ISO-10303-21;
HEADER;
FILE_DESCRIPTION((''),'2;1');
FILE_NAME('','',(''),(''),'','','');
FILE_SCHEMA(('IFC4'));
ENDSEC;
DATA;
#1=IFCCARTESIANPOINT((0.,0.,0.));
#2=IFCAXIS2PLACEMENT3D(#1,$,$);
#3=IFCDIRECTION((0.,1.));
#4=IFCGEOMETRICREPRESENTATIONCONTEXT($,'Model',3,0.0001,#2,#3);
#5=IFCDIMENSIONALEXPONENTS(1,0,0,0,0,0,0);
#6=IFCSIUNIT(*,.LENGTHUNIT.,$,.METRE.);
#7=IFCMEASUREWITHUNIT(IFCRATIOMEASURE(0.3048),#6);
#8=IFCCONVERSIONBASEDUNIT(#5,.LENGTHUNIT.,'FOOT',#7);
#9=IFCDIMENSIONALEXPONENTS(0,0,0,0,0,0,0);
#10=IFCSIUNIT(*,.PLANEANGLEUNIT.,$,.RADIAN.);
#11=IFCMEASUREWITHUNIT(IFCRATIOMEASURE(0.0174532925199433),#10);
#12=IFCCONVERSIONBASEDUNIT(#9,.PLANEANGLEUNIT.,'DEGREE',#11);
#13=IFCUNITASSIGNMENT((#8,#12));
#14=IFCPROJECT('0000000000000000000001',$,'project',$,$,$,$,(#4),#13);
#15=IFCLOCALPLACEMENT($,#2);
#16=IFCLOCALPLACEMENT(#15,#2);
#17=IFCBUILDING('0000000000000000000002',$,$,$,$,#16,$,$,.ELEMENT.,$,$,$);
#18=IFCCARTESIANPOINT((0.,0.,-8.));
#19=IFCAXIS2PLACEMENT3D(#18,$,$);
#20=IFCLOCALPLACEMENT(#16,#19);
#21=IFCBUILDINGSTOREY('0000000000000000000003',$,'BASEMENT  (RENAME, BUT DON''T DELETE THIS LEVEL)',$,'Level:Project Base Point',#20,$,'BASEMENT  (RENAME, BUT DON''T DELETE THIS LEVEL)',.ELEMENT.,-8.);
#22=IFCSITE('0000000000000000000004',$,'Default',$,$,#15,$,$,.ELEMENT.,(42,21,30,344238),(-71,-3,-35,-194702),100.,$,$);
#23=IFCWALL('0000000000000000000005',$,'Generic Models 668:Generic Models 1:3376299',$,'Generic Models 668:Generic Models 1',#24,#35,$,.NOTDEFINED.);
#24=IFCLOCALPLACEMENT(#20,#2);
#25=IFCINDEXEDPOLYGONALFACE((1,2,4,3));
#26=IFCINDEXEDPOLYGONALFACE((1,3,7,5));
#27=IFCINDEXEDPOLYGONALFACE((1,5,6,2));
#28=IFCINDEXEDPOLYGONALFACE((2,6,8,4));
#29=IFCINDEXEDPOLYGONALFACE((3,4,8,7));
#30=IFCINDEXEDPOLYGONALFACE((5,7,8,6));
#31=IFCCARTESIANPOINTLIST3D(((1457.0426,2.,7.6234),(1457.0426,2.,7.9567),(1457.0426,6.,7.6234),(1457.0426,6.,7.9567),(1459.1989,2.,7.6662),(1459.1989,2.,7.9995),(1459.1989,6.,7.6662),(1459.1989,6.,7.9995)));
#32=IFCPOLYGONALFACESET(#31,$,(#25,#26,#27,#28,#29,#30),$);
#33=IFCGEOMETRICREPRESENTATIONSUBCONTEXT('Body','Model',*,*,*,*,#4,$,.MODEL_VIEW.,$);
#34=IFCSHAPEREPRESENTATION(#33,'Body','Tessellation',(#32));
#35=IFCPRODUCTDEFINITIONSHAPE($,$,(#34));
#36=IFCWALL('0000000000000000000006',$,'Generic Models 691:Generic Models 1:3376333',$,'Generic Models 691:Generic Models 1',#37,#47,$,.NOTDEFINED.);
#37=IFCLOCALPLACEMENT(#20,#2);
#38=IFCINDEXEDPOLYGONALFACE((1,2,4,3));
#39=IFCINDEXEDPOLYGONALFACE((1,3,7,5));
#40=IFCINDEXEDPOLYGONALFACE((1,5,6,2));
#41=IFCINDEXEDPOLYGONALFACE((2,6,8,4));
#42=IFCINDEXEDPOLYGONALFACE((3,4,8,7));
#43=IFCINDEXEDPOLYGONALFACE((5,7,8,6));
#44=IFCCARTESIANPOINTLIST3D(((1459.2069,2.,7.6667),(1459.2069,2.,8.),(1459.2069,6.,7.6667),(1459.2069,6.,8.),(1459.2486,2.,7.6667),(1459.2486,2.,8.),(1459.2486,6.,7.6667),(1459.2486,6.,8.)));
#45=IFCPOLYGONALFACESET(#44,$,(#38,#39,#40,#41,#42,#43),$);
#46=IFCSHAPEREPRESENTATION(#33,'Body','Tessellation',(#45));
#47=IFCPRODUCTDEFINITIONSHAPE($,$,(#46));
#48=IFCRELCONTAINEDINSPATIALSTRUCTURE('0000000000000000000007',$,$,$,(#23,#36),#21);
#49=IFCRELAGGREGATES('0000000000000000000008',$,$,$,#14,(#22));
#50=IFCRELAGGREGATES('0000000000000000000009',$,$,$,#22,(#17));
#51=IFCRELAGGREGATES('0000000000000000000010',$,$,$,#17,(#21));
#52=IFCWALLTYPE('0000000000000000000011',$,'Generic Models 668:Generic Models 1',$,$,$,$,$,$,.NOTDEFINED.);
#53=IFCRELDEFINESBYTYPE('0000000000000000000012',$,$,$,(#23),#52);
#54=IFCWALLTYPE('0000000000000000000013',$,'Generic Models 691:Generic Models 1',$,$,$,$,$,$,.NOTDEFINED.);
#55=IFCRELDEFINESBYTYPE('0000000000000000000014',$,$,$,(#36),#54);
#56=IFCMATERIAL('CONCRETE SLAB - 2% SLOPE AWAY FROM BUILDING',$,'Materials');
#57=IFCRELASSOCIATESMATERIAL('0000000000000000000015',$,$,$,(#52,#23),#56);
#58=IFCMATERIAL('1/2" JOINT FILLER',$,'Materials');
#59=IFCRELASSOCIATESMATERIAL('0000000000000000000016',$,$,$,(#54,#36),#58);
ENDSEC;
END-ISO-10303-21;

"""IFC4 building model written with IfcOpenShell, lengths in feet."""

from ifc_helpers import new_model, entity, si_unit, converted_unit, direction, frame, frame_2d, origin, place, context, subcontext, project, spatial, rectangle, extrude, material, type_object, element, save


model = new_model("IFC4")

# Units and contexts
model_context = context("Model", 3, precision=0.0001, world=origin(), true_north=direction((0.0, 1.0)))
body_context = subcontext(model_context, "Body", "Model", "MODEL_VIEW")
ifc_project = project(units=[converted_unit("LENGTHUNIT", "FOOT", entity("IfcRatioMeasure", 0.3048), si_unit("LENGTHUNIT", "METRE"), dimensions=[1, 0, 0, 0, 0, 0, 0]), converted_unit("PLANEANGLEUNIT", "DEGREE", entity("IfcRatioMeasure", 0.0174532925199433), si_unit("PLANEANGLEUNIT", "RADIAN"), dimensions=[0, 0, 0, 0, 0, 0, 0])], contexts=[model_context])

# Site, building, storey
site_placement = place(None, origin())
site = spatial("IfcSite", under=ifc_project, at=site_placement, Name="Default", CompositionType="ELEMENT", RefLatitude=(42, 21, 30, 344238), RefLongitude=(-71, -3, -35, -194702), RefElevation=100.0)
building_placement = place(site_placement, origin())
building = spatial("IfcBuilding", under=site, at=building_placement, CompositionType="ELEMENT")
storey_placement = place(building_placement, frame((0.0, 0.0, -8.0)))
storey = spatial("IfcBuildingStorey", under=building, at=storey_placement, Name="BASEMENT  (RENAME, BUT DON'T DELETE THIS LEVEL)", ObjectType="Level:Project Base Point", LongName="BASEMENT  (RENAME, BUT DON'T DELETE THIS LEVEL)", CompositionType="ELEMENT", Elevation=-8.0)

# Walls
ifc_material_1 = material(Name="CONCRETE SLAB - 2% SLOPE AWAY FROM BUILDING", Category="Materials")
wall_type_1 = type_object("IfcWallType", Name="Generic Models 668:Generic Models 1", PredefinedType="NOTDEFINED", material=ifc_material_1)
wall_1_placement = place(storey_placement, frame((1457.0426, 2.0, 7.6234), z_axis=(0.0, 0.0, 1.0), x_axis=(0.0, 1.0, 0.0)))
element("IfcWall", 1, at=wall_1_placement, inside=storey, type_object=wall_type_1, material=ifc_material_1, Name="Generic Models 668:Generic Models 1:3376299", ObjectType="Generic Models 668:Generic Models 1", PredefinedType="NOTDEFINED", context=body_context, shape_type="SweptSolid", body=[
    extrude(rectangle(XDim=2.1567, YDim=4.0, at=frame_2d((0.0, 0.0), x_axis=(0.0, 1.0))), frame((2.0, -1.0781, 0.0214), z_axis=(0.0, 0.019853, 0.999803), x_axis=(1.0, 0.0, 0.0)), (0.0, -0.019853, 0.999803), 0.3333),
])
ifc_material_2 = material(Name="1/2\" JOINT FILLER", Category="Materials")
wall_type_2 = type_object("IfcWallType", Name="Generic Models 691:Generic Models 1", PredefinedType="NOTDEFINED", material=ifc_material_2)
wall_2_placement = place(storey_placement, frame((1459.2069, 2.0, 7.6667), z_axis=(0.0, 0.0, 1.0), x_axis=(0.0, 1.0, 0.0)))
element("IfcWall", 2, at=wall_2_placement, inside=storey, type_object=wall_type_2, material=ifc_material_2, Name="Generic Models 691:Generic Models 1:3376333", ObjectType="Generic Models 691:Generic Models 1", PredefinedType="NOTDEFINED", context=body_context, shape_type="SweptSolid", body=[
    extrude(rectangle(XDim=4.0, YDim=0.0417, at=frame_2d((0.0, 0.0), x_axis=(1.0, 0.0))), frame((2.0, -0.0208, 0.0)), (0.0, 0.0, 1.0), 0.3333),
])

save(model, "model.ifc")
